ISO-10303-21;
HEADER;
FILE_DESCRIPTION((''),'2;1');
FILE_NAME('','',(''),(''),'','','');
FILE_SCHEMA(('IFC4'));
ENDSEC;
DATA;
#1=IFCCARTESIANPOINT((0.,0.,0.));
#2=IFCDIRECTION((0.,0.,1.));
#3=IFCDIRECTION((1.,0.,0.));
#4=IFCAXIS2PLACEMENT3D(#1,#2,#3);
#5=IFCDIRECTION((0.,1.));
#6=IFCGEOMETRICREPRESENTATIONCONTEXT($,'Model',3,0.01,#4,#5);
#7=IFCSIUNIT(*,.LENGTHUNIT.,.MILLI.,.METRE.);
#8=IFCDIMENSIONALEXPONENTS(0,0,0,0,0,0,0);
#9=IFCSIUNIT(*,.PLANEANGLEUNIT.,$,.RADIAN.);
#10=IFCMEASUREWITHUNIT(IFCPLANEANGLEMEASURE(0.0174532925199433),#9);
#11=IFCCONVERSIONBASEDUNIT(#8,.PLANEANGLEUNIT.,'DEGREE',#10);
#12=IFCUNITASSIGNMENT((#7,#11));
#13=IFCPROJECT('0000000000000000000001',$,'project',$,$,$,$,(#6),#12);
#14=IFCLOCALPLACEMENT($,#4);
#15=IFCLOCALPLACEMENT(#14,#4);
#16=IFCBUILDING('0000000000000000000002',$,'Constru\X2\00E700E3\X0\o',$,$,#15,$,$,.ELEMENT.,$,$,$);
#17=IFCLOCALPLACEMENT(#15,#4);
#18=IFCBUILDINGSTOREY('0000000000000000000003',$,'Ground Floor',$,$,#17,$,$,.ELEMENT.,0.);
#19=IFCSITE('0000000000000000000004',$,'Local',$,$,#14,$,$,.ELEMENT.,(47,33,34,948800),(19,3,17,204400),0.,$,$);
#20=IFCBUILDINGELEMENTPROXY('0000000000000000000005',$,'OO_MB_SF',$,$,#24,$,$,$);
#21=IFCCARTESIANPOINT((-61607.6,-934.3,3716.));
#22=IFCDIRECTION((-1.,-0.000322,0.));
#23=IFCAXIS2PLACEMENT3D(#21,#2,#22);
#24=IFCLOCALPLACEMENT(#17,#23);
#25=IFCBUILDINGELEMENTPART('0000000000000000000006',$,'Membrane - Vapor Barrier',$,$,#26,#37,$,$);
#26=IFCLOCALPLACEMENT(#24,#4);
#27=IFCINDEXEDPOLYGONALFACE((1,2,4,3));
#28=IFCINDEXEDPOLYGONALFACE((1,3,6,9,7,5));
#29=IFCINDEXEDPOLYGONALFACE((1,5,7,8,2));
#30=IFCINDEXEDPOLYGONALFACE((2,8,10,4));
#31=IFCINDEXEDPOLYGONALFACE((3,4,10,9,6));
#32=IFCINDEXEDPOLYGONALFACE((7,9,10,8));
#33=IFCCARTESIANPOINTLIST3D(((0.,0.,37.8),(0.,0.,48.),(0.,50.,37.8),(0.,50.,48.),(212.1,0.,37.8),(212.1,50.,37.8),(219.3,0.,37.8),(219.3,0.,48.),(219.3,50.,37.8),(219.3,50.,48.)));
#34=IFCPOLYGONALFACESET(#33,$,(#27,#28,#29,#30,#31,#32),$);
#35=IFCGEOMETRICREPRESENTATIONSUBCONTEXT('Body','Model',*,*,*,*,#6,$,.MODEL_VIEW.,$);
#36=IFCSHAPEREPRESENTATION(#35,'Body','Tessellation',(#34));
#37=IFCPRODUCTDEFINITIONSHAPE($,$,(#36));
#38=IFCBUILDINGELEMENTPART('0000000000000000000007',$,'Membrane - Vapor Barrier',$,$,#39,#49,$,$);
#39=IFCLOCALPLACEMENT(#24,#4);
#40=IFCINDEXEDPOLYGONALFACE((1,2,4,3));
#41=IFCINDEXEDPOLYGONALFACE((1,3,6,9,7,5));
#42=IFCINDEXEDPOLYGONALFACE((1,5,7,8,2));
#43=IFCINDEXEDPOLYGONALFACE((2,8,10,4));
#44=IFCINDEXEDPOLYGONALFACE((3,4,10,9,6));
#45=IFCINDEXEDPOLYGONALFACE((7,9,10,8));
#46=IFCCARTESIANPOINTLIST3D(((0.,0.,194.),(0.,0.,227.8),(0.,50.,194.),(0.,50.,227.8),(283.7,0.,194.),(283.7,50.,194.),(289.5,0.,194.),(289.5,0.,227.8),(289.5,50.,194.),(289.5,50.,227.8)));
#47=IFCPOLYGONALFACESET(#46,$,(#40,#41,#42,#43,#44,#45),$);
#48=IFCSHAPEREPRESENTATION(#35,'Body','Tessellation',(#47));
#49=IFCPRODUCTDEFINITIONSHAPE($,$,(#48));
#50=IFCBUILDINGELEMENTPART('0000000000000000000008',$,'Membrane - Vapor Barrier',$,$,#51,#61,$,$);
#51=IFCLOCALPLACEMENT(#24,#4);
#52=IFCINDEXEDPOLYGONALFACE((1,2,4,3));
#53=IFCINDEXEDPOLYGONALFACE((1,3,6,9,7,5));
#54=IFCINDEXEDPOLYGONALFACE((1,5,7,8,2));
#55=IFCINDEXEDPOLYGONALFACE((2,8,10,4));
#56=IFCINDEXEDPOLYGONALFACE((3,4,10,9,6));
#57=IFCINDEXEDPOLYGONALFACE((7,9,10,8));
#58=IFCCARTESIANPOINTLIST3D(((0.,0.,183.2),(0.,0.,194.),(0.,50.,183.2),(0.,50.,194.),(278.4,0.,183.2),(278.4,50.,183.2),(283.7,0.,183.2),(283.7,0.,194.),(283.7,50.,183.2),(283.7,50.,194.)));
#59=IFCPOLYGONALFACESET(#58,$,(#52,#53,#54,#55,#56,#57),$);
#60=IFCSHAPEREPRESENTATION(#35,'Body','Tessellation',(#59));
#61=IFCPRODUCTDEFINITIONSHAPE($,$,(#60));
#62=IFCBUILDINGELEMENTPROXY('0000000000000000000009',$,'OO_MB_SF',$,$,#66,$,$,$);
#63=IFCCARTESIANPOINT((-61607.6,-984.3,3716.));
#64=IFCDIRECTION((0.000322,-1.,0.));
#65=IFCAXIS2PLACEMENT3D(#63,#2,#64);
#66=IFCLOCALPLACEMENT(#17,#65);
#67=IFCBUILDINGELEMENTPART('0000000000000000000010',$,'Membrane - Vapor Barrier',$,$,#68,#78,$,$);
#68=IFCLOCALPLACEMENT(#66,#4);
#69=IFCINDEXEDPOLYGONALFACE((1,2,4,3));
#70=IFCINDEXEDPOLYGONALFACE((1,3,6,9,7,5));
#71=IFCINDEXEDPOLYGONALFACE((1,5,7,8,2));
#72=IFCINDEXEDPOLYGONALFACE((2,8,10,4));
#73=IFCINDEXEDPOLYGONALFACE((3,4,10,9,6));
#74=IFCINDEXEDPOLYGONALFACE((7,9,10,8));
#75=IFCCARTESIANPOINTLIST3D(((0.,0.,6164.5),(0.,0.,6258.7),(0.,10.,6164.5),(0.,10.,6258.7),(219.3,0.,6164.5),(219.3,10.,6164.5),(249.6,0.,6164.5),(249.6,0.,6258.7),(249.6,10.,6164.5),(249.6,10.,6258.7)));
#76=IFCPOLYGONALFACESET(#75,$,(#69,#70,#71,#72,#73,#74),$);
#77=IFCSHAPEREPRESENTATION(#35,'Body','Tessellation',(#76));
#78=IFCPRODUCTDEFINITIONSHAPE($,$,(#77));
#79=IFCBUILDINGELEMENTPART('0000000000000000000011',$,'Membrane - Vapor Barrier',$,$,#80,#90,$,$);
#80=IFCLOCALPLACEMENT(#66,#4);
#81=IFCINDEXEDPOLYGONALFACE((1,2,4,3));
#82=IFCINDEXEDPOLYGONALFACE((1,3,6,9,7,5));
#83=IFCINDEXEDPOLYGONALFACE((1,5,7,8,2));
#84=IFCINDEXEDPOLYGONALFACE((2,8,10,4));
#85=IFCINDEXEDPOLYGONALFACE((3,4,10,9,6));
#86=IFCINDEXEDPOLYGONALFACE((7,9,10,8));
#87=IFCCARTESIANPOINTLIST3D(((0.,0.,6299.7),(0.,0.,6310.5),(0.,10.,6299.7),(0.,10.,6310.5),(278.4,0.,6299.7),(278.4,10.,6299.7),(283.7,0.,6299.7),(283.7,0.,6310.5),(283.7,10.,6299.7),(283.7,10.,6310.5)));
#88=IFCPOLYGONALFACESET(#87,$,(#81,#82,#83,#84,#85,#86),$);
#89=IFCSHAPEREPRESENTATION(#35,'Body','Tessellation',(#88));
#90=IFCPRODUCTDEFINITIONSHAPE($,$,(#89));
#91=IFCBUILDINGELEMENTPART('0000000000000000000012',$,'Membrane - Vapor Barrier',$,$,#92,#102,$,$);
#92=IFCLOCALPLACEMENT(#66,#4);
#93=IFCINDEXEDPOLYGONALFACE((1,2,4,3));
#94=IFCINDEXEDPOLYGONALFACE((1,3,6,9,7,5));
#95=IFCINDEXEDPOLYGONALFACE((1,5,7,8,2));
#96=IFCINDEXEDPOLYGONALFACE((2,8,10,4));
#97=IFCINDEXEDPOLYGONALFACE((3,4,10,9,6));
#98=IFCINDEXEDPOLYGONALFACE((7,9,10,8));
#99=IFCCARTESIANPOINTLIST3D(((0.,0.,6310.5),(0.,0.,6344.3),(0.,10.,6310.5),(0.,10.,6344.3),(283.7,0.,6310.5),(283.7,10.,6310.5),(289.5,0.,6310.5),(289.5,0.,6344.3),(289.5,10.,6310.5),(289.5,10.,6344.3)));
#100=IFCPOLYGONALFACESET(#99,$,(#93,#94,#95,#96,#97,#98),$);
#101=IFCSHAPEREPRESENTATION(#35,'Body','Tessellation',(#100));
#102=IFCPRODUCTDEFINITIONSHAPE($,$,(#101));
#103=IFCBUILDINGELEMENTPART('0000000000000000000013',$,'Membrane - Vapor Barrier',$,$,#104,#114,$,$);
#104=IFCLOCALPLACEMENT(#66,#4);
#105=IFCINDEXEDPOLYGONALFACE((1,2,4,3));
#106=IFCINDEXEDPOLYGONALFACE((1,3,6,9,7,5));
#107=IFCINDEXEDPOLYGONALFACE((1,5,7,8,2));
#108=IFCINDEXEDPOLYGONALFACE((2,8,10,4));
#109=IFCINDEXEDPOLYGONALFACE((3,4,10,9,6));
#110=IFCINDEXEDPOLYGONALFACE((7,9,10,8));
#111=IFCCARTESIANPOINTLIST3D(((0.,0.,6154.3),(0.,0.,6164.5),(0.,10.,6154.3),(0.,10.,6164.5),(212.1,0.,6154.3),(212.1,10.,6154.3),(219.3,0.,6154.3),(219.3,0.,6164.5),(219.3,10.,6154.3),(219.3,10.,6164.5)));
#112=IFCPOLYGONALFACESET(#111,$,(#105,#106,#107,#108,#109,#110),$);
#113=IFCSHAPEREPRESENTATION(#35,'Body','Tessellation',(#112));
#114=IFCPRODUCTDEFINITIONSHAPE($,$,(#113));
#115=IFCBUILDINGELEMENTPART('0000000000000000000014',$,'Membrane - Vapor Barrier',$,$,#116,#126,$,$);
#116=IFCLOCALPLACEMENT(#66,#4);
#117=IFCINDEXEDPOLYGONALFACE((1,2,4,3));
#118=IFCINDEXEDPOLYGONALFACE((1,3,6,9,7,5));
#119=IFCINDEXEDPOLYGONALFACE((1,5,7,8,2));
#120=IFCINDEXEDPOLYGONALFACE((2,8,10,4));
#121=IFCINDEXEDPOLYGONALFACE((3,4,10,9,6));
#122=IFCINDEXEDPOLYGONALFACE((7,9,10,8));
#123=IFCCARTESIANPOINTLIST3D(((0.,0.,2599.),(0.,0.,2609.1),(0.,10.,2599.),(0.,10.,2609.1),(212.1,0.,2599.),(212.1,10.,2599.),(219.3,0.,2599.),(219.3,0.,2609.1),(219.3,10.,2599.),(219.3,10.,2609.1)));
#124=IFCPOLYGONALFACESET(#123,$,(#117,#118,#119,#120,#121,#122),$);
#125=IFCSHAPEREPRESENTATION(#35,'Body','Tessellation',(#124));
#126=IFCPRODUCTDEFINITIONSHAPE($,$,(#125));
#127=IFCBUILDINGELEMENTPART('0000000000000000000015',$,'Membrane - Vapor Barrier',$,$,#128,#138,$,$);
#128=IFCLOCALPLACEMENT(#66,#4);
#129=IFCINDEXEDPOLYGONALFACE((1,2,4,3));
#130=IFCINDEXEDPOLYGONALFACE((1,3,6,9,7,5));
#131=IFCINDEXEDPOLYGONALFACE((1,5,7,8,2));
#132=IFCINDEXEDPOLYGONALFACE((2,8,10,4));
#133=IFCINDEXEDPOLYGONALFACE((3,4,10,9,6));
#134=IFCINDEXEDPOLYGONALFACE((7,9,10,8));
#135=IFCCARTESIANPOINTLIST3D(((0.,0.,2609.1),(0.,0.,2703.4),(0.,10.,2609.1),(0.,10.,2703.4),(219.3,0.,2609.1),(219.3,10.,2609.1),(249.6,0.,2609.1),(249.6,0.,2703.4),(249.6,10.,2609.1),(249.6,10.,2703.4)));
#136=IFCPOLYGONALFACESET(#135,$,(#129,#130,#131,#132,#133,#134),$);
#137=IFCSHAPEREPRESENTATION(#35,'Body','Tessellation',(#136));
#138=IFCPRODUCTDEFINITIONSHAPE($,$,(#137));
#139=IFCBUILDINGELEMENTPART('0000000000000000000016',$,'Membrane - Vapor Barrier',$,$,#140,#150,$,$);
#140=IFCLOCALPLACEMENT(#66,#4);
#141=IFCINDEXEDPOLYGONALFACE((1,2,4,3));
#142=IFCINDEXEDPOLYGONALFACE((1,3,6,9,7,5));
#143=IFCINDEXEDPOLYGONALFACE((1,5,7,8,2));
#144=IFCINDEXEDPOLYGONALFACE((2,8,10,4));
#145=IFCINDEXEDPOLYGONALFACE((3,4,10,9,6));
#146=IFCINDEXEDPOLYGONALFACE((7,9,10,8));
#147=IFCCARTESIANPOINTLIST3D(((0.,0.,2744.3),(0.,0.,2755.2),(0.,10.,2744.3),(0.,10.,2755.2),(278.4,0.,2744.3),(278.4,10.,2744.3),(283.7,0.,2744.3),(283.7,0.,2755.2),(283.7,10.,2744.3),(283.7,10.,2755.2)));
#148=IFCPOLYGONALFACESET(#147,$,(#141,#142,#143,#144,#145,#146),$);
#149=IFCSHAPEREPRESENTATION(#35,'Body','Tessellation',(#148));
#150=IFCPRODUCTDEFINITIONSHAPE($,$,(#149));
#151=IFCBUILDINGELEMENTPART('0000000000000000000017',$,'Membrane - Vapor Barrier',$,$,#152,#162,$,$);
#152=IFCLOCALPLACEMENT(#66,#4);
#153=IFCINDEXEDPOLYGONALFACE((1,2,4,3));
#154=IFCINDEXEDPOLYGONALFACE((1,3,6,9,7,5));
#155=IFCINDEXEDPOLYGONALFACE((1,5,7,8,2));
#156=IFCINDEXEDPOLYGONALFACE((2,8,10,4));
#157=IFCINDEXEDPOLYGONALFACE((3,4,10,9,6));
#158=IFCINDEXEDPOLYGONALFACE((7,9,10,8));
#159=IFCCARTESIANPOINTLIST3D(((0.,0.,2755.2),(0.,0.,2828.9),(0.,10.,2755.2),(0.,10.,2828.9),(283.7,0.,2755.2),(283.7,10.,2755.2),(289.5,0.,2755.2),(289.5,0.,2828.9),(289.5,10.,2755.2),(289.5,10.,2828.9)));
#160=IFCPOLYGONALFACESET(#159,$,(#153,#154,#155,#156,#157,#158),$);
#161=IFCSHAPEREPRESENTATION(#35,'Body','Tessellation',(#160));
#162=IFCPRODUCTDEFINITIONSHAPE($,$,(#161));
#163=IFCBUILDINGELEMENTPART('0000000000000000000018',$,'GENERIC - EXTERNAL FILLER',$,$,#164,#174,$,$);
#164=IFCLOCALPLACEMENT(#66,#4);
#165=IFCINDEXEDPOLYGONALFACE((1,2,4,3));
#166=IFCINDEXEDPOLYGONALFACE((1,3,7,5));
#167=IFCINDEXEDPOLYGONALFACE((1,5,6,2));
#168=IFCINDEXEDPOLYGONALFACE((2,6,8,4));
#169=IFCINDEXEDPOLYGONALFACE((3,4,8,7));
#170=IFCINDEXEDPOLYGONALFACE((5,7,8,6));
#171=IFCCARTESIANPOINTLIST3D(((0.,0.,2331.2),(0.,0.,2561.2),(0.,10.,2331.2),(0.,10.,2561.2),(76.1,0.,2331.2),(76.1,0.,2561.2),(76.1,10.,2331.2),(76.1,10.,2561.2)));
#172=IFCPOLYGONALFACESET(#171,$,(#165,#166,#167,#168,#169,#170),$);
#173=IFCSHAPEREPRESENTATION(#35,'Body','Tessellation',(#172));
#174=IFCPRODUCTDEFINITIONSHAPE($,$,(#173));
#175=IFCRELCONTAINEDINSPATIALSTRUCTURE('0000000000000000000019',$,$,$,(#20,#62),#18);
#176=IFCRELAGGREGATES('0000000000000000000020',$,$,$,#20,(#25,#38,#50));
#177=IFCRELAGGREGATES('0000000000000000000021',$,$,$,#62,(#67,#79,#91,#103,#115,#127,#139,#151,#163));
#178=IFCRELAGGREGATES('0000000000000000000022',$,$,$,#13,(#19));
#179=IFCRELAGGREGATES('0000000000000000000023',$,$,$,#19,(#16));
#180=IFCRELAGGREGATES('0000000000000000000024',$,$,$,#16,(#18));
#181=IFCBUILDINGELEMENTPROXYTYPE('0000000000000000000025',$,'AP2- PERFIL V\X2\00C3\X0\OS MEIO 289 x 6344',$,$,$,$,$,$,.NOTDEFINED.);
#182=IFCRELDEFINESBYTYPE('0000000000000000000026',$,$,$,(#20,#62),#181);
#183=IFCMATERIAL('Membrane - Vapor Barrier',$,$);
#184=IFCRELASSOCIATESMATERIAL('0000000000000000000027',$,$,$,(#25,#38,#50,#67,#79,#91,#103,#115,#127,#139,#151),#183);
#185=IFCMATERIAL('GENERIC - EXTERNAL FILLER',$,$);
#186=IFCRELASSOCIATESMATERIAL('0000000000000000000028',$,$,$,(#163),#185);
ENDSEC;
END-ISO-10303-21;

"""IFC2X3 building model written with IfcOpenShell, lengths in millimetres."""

from ifc_helpers import new_model, entity, si_unit, converted_unit, direction, frame, origin_with_axes, place, context, subcontext, project, spatial, polyline, outline, extrude, material, type_object, element, aggregate, save


model = new_model("IFC2X3")

# Units and contexts
model_context = context("Model", 3, precision=0.01, world=origin_with_axes(), true_north=direction((0.0, 1.0)))
body_context = subcontext(model_context, "Body", "Model", "MODEL_VIEW")
ifc_project = project(units=[si_unit("LENGTHUNIT", "METRE", prefix="MILLI"), converted_unit("PLANEANGLEUNIT", "DEGREE", entity("IfcPlaneAngleMeasure", 0.0174532925199433), si_unit("PLANEANGLEUNIT", "RADIAN"), dimensions=[0, 0, 0, 0, 0, 0, 0])], contexts=[model_context])

# Site, building, storey
site_placement = place(None, origin_with_axes())
site = spatial("IfcSite", under=ifc_project, at=site_placement, Name="Local", CompositionType="ELEMENT", RefLatitude=(47, 33, 34, 948800), RefLongitude=(19, 3, 17, 204400), RefElevation=0.0)
building_placement = place(site_placement, origin_with_axes())
building = spatial("IfcBuilding", under=site, at=building_placement, Name="Construção", CompositionType="ELEMENT")
storey_placement = place(building_placement, origin_with_axes())
storey = spatial("IfcBuildingStorey", under=building, at=storey_placement, Name="Ground Floor", CompositionType="ELEMENT", Elevation=0.0)

# Building element proxies, building element parts
building_element_proxy_type = type_object("IfcBuildingElementProxyType", Name="AP2- PERFIL VÃOS MEIO 289 x 6344", PredefinedType="NOTDEFINED")
proxy_1_placement = place(storey_placement, frame((-61607.6, -934.3, 3716.0), z_axis=(0.0, 0.0, 1.0), x_axis=(-1.0, -0.000322, 0.0)))
proxy_1 = element("IfcBuildingElementProxy", 1, at=proxy_1_placement, inside=storey, type_object=building_element_proxy_type, Name="OO_MB_SF")
ifc_material_1 = material(Name="Membrane - Vapor Barrier")
ifc_material_2 = material(Name="GENERIC - EXTERNAL FILLER")
building_element_part_1_placement = place(proxy_1_placement, origin_with_axes())
building_element_part_1 = element("IfcBuildingElementPart", 2, at=building_element_part_1_placement, material=ifc_material_1, Name="Membrane - Vapor Barrier", context=body_context, shape_type="SweptSolid", body=[
    extrude(outline(polyline([(0.0, 37.8), (212.1, 37.8), (219.3, 37.8), (219.3, 48.0), (0.0, 48.0), (0.0, 37.8)])), frame((0.0, 50.0, 0.0), z_axis=(0.0, -1.0, 0.0), x_axis=(1.0, 0.0, 0.0)), (0.0, 0.0, 1.0), 50.0),
])
building_element_part_2_placement = place(proxy_1_placement, origin_with_axes())
building_element_part_2 = element("IfcBuildingElementPart", 3, at=building_element_part_2_placement, material=ifc_material_1, Name="Membrane - Vapor Barrier", context=body_context, shape_type="SweptSolid", body=[
    extrude(outline(polyline([(0.0, 194.0), (283.7, 194.0), (289.5, 194.0), (289.5, 227.8), (0.0, 227.8), (0.0, 194.0)])), frame((0.0, 50.0, 0.0), z_axis=(0.0, -1.0, 0.0), x_axis=(1.0, 0.0, 0.0)), (0.0, 0.0, 1.0), 50.0),
])
building_element_part_3_placement = place(proxy_1_placement, origin_with_axes())
building_element_part_3 = element("IfcBuildingElementPart", 4, at=building_element_part_3_placement, material=ifc_material_1, Name="Membrane - Vapor Barrier", context=body_context, shape_type="SweptSolid", body=[
    extrude(outline(polyline([(0.0, 183.2), (278.4, 183.2), (283.7, 183.2), (283.7, 194.0), (0.0, 194.0), (0.0, 183.2)])), frame((0.0, 50.0, 0.0), z_axis=(0.0, -1.0, 0.0), x_axis=(1.0, 0.0, 0.0)), (0.0, 0.0, 1.0), 50.0),
])
aggregate(proxy_1, [building_element_part_1, building_element_part_2, building_element_part_3])
proxy_2_placement = place(storey_placement, frame((-61607.6, -984.3, 3716.0), z_axis=(0.0, 0.0, 1.0), x_axis=(0.000322, -1.0, 0.0)))
proxy_2 = element("IfcBuildingElementProxy", 5, at=proxy_2_placement, inside=storey, type_object=building_element_proxy_type, Name="OO_MB_SF")
building_element_part_4_placement = place(proxy_2_placement, origin_with_axes())
building_element_part_4 = element("IfcBuildingElementPart", 6, at=building_element_part_4_placement, material=ifc_material_1, Name="Membrane - Vapor Barrier", context=body_context, shape_type="SweptSolid", body=[
    extrude(outline(polyline([(249.6, 6258.7), (0.0, 6258.7), (0.0, 6164.5), (219.3, 6164.5), (249.6, 6164.5), (249.6, 6258.7)])), frame((0.0, 10.0, 0.0), z_axis=(0.0, -1.0, 0.0), x_axis=(1.0, 0.0, 0.0)), (0.0, 0.0, 1.0), 10.0),
])
building_element_part_5_placement = place(proxy_2_placement, origin_with_axes())
building_element_part_5 = element("IfcBuildingElementPart", 7, at=building_element_part_5_placement, material=ifc_material_1, Name="Membrane - Vapor Barrier", context=body_context, shape_type="SweptSolid", body=[
    extrude(outline(polyline([(0.0, 6299.7), (278.4, 6299.7), (283.7, 6299.7), (283.7, 6310.5), (0.0, 6310.5), (0.0, 6299.7)])), frame((0.0, 10.0, 0.0), z_axis=(0.0, -1.0, 0.0), x_axis=(1.0, 0.0, 0.0)), (0.0, 0.0, 1.0), 10.0),
])
building_element_part_6_placement = place(proxy_2_placement, origin_with_axes())
building_element_part_6 = element("IfcBuildingElementPart", 8, at=building_element_part_6_placement, material=ifc_material_1, Name="Membrane - Vapor Barrier", context=body_context, shape_type="SweptSolid", body=[
    extrude(outline(polyline([(0.0, 6310.5), (283.7, 6310.5), (289.5, 6310.5), (289.5, 6344.3), (0.0, 6344.3), (0.0, 6310.5)])), frame((0.0, 10.0, 0.0), z_axis=(0.0, -1.0, 0.0), x_axis=(1.0, 0.0, 0.0)), (0.0, 0.0, 1.0), 10.0),
])
building_element_part_7_placement = place(proxy_2_placement, origin_with_axes())
building_element_part_7 = element("IfcBuildingElementPart", 9, at=building_element_part_7_placement, material=ifc_material_1, Name="Membrane - Vapor Barrier", context=body_context, shape_type="SweptSolid", body=[
    extrude(outline(polyline([(0.0, 6154.3), (212.1, 6154.3), (219.3, 6154.3), (219.3, 6164.5), (0.0, 6164.5), (0.0, 6154.3)])), frame((0.0, 10.0, 0.0), z_axis=(0.0, -1.0, 0.0), x_axis=(1.0, 0.0, 0.0)), (0.0, 0.0, 1.0), 10.0),
])
building_element_part_8_placement = place(proxy_2_placement, origin_with_axes())
building_element_part_8 = element("IfcBuildingElementPart", 10, at=building_element_part_8_placement, material=ifc_material_1, Name="Membrane - Vapor Barrier", context=body_context, shape_type="SweptSolid", body=[
    extrude(outline(polyline([(0.0, 2599.0), (212.1, 2599.0), (219.3, 2599.0), (219.3, 2609.1), (0.0, 2609.1), (0.0, 2599.0)])), frame((0.0, 10.0, 0.0), z_axis=(0.0, -1.0, 0.0), x_axis=(1.0, 0.0, 0.0)), (0.0, 0.0, 1.0), 10.0),
])
building_element_part_9_placement = place(proxy_2_placement, origin_with_axes())
building_element_part_9 = element("IfcBuildingElementPart", 11, at=building_element_part_9_placement, material=ifc_material_1, Name="Membrane - Vapor Barrier", context=body_context, shape_type="SweptSolid", body=[
    extrude(outline(polyline([(249.6, 2703.4), (0.0, 2703.4), (0.0, 2609.1), (219.3, 2609.1), (249.6, 2609.1), (249.6, 2703.4)])), frame((0.0, 10.0, 0.0), z_axis=(0.0, -1.0, 0.0), x_axis=(1.0, 0.0, 0.0)), (0.0, 0.0, 1.0), 10.0),
])
building_element_part_10_placement = place(proxy_2_placement, origin_with_axes())
building_element_part_10 = element("IfcBuildingElementPart", 12, at=building_element_part_10_placement, material=ifc_material_1, Name="Membrane - Vapor Barrier", context=body_context, shape_type="SweptSolid", body=[
    extrude(outline(polyline([(0.0, 2744.3), (278.4, 2744.3), (283.7, 2744.3), (283.7, 2755.2), (0.0, 2755.2), (0.0, 2744.3)])), frame((0.0, 10.0, 0.0), z_axis=(0.0, -1.0, 0.0), x_axis=(1.0, 0.0, 0.0)), (0.0, 0.0, 1.0), 10.0),
])
building_element_part_11_placement = place(proxy_2_placement, origin_with_axes())
building_element_part_11 = element("IfcBuildingElementPart", 13, at=building_element_part_11_placement, material=ifc_material_1, Name="Membrane - Vapor Barrier", context=body_context, shape_type="SweptSolid", body=[
    extrude(outline(polyline([(0.0, 2755.2), (283.7, 2755.2), (289.5, 2755.2), (289.5, 2828.9), (0.0, 2828.9), (0.0, 2755.2)])), frame((0.0, 10.0, 0.0), z_axis=(0.0, -1.0, 0.0), x_axis=(1.0, 0.0, 0.0)), (0.0, 0.0, 1.0), 10.0),
])
building_element_part_12_placement = place(proxy_2_placement, origin_with_axes())
building_element_part_12 = element("IfcBuildingElementPart", 14, at=building_element_part_12_placement, material=ifc_material_2, Name="GENERIC - EXTERNAL FILLER", context=body_context, shape_type="SweptSolid", body=[
    extrude(outline(polyline([(76.1, 2561.2), (0.0, 2561.2), (0.0, 2331.2), (76.1, 2331.2), (76.1, 2561.2)])), frame((0.0, 10.0, 0.0), z_axis=(0.0, -1.0, 0.0), x_axis=(1.0, 0.0, 0.0)), (0.0, 0.0, 1.0), 10.0),
])
aggregate(proxy_2, [building_element_part_4, building_element_part_5, building_element_part_6, building_element_part_7, building_element_part_8, building_element_part_9, building_element_part_10, building_element_part_11, building_element_part_12])

save(model, "model.ifc")
